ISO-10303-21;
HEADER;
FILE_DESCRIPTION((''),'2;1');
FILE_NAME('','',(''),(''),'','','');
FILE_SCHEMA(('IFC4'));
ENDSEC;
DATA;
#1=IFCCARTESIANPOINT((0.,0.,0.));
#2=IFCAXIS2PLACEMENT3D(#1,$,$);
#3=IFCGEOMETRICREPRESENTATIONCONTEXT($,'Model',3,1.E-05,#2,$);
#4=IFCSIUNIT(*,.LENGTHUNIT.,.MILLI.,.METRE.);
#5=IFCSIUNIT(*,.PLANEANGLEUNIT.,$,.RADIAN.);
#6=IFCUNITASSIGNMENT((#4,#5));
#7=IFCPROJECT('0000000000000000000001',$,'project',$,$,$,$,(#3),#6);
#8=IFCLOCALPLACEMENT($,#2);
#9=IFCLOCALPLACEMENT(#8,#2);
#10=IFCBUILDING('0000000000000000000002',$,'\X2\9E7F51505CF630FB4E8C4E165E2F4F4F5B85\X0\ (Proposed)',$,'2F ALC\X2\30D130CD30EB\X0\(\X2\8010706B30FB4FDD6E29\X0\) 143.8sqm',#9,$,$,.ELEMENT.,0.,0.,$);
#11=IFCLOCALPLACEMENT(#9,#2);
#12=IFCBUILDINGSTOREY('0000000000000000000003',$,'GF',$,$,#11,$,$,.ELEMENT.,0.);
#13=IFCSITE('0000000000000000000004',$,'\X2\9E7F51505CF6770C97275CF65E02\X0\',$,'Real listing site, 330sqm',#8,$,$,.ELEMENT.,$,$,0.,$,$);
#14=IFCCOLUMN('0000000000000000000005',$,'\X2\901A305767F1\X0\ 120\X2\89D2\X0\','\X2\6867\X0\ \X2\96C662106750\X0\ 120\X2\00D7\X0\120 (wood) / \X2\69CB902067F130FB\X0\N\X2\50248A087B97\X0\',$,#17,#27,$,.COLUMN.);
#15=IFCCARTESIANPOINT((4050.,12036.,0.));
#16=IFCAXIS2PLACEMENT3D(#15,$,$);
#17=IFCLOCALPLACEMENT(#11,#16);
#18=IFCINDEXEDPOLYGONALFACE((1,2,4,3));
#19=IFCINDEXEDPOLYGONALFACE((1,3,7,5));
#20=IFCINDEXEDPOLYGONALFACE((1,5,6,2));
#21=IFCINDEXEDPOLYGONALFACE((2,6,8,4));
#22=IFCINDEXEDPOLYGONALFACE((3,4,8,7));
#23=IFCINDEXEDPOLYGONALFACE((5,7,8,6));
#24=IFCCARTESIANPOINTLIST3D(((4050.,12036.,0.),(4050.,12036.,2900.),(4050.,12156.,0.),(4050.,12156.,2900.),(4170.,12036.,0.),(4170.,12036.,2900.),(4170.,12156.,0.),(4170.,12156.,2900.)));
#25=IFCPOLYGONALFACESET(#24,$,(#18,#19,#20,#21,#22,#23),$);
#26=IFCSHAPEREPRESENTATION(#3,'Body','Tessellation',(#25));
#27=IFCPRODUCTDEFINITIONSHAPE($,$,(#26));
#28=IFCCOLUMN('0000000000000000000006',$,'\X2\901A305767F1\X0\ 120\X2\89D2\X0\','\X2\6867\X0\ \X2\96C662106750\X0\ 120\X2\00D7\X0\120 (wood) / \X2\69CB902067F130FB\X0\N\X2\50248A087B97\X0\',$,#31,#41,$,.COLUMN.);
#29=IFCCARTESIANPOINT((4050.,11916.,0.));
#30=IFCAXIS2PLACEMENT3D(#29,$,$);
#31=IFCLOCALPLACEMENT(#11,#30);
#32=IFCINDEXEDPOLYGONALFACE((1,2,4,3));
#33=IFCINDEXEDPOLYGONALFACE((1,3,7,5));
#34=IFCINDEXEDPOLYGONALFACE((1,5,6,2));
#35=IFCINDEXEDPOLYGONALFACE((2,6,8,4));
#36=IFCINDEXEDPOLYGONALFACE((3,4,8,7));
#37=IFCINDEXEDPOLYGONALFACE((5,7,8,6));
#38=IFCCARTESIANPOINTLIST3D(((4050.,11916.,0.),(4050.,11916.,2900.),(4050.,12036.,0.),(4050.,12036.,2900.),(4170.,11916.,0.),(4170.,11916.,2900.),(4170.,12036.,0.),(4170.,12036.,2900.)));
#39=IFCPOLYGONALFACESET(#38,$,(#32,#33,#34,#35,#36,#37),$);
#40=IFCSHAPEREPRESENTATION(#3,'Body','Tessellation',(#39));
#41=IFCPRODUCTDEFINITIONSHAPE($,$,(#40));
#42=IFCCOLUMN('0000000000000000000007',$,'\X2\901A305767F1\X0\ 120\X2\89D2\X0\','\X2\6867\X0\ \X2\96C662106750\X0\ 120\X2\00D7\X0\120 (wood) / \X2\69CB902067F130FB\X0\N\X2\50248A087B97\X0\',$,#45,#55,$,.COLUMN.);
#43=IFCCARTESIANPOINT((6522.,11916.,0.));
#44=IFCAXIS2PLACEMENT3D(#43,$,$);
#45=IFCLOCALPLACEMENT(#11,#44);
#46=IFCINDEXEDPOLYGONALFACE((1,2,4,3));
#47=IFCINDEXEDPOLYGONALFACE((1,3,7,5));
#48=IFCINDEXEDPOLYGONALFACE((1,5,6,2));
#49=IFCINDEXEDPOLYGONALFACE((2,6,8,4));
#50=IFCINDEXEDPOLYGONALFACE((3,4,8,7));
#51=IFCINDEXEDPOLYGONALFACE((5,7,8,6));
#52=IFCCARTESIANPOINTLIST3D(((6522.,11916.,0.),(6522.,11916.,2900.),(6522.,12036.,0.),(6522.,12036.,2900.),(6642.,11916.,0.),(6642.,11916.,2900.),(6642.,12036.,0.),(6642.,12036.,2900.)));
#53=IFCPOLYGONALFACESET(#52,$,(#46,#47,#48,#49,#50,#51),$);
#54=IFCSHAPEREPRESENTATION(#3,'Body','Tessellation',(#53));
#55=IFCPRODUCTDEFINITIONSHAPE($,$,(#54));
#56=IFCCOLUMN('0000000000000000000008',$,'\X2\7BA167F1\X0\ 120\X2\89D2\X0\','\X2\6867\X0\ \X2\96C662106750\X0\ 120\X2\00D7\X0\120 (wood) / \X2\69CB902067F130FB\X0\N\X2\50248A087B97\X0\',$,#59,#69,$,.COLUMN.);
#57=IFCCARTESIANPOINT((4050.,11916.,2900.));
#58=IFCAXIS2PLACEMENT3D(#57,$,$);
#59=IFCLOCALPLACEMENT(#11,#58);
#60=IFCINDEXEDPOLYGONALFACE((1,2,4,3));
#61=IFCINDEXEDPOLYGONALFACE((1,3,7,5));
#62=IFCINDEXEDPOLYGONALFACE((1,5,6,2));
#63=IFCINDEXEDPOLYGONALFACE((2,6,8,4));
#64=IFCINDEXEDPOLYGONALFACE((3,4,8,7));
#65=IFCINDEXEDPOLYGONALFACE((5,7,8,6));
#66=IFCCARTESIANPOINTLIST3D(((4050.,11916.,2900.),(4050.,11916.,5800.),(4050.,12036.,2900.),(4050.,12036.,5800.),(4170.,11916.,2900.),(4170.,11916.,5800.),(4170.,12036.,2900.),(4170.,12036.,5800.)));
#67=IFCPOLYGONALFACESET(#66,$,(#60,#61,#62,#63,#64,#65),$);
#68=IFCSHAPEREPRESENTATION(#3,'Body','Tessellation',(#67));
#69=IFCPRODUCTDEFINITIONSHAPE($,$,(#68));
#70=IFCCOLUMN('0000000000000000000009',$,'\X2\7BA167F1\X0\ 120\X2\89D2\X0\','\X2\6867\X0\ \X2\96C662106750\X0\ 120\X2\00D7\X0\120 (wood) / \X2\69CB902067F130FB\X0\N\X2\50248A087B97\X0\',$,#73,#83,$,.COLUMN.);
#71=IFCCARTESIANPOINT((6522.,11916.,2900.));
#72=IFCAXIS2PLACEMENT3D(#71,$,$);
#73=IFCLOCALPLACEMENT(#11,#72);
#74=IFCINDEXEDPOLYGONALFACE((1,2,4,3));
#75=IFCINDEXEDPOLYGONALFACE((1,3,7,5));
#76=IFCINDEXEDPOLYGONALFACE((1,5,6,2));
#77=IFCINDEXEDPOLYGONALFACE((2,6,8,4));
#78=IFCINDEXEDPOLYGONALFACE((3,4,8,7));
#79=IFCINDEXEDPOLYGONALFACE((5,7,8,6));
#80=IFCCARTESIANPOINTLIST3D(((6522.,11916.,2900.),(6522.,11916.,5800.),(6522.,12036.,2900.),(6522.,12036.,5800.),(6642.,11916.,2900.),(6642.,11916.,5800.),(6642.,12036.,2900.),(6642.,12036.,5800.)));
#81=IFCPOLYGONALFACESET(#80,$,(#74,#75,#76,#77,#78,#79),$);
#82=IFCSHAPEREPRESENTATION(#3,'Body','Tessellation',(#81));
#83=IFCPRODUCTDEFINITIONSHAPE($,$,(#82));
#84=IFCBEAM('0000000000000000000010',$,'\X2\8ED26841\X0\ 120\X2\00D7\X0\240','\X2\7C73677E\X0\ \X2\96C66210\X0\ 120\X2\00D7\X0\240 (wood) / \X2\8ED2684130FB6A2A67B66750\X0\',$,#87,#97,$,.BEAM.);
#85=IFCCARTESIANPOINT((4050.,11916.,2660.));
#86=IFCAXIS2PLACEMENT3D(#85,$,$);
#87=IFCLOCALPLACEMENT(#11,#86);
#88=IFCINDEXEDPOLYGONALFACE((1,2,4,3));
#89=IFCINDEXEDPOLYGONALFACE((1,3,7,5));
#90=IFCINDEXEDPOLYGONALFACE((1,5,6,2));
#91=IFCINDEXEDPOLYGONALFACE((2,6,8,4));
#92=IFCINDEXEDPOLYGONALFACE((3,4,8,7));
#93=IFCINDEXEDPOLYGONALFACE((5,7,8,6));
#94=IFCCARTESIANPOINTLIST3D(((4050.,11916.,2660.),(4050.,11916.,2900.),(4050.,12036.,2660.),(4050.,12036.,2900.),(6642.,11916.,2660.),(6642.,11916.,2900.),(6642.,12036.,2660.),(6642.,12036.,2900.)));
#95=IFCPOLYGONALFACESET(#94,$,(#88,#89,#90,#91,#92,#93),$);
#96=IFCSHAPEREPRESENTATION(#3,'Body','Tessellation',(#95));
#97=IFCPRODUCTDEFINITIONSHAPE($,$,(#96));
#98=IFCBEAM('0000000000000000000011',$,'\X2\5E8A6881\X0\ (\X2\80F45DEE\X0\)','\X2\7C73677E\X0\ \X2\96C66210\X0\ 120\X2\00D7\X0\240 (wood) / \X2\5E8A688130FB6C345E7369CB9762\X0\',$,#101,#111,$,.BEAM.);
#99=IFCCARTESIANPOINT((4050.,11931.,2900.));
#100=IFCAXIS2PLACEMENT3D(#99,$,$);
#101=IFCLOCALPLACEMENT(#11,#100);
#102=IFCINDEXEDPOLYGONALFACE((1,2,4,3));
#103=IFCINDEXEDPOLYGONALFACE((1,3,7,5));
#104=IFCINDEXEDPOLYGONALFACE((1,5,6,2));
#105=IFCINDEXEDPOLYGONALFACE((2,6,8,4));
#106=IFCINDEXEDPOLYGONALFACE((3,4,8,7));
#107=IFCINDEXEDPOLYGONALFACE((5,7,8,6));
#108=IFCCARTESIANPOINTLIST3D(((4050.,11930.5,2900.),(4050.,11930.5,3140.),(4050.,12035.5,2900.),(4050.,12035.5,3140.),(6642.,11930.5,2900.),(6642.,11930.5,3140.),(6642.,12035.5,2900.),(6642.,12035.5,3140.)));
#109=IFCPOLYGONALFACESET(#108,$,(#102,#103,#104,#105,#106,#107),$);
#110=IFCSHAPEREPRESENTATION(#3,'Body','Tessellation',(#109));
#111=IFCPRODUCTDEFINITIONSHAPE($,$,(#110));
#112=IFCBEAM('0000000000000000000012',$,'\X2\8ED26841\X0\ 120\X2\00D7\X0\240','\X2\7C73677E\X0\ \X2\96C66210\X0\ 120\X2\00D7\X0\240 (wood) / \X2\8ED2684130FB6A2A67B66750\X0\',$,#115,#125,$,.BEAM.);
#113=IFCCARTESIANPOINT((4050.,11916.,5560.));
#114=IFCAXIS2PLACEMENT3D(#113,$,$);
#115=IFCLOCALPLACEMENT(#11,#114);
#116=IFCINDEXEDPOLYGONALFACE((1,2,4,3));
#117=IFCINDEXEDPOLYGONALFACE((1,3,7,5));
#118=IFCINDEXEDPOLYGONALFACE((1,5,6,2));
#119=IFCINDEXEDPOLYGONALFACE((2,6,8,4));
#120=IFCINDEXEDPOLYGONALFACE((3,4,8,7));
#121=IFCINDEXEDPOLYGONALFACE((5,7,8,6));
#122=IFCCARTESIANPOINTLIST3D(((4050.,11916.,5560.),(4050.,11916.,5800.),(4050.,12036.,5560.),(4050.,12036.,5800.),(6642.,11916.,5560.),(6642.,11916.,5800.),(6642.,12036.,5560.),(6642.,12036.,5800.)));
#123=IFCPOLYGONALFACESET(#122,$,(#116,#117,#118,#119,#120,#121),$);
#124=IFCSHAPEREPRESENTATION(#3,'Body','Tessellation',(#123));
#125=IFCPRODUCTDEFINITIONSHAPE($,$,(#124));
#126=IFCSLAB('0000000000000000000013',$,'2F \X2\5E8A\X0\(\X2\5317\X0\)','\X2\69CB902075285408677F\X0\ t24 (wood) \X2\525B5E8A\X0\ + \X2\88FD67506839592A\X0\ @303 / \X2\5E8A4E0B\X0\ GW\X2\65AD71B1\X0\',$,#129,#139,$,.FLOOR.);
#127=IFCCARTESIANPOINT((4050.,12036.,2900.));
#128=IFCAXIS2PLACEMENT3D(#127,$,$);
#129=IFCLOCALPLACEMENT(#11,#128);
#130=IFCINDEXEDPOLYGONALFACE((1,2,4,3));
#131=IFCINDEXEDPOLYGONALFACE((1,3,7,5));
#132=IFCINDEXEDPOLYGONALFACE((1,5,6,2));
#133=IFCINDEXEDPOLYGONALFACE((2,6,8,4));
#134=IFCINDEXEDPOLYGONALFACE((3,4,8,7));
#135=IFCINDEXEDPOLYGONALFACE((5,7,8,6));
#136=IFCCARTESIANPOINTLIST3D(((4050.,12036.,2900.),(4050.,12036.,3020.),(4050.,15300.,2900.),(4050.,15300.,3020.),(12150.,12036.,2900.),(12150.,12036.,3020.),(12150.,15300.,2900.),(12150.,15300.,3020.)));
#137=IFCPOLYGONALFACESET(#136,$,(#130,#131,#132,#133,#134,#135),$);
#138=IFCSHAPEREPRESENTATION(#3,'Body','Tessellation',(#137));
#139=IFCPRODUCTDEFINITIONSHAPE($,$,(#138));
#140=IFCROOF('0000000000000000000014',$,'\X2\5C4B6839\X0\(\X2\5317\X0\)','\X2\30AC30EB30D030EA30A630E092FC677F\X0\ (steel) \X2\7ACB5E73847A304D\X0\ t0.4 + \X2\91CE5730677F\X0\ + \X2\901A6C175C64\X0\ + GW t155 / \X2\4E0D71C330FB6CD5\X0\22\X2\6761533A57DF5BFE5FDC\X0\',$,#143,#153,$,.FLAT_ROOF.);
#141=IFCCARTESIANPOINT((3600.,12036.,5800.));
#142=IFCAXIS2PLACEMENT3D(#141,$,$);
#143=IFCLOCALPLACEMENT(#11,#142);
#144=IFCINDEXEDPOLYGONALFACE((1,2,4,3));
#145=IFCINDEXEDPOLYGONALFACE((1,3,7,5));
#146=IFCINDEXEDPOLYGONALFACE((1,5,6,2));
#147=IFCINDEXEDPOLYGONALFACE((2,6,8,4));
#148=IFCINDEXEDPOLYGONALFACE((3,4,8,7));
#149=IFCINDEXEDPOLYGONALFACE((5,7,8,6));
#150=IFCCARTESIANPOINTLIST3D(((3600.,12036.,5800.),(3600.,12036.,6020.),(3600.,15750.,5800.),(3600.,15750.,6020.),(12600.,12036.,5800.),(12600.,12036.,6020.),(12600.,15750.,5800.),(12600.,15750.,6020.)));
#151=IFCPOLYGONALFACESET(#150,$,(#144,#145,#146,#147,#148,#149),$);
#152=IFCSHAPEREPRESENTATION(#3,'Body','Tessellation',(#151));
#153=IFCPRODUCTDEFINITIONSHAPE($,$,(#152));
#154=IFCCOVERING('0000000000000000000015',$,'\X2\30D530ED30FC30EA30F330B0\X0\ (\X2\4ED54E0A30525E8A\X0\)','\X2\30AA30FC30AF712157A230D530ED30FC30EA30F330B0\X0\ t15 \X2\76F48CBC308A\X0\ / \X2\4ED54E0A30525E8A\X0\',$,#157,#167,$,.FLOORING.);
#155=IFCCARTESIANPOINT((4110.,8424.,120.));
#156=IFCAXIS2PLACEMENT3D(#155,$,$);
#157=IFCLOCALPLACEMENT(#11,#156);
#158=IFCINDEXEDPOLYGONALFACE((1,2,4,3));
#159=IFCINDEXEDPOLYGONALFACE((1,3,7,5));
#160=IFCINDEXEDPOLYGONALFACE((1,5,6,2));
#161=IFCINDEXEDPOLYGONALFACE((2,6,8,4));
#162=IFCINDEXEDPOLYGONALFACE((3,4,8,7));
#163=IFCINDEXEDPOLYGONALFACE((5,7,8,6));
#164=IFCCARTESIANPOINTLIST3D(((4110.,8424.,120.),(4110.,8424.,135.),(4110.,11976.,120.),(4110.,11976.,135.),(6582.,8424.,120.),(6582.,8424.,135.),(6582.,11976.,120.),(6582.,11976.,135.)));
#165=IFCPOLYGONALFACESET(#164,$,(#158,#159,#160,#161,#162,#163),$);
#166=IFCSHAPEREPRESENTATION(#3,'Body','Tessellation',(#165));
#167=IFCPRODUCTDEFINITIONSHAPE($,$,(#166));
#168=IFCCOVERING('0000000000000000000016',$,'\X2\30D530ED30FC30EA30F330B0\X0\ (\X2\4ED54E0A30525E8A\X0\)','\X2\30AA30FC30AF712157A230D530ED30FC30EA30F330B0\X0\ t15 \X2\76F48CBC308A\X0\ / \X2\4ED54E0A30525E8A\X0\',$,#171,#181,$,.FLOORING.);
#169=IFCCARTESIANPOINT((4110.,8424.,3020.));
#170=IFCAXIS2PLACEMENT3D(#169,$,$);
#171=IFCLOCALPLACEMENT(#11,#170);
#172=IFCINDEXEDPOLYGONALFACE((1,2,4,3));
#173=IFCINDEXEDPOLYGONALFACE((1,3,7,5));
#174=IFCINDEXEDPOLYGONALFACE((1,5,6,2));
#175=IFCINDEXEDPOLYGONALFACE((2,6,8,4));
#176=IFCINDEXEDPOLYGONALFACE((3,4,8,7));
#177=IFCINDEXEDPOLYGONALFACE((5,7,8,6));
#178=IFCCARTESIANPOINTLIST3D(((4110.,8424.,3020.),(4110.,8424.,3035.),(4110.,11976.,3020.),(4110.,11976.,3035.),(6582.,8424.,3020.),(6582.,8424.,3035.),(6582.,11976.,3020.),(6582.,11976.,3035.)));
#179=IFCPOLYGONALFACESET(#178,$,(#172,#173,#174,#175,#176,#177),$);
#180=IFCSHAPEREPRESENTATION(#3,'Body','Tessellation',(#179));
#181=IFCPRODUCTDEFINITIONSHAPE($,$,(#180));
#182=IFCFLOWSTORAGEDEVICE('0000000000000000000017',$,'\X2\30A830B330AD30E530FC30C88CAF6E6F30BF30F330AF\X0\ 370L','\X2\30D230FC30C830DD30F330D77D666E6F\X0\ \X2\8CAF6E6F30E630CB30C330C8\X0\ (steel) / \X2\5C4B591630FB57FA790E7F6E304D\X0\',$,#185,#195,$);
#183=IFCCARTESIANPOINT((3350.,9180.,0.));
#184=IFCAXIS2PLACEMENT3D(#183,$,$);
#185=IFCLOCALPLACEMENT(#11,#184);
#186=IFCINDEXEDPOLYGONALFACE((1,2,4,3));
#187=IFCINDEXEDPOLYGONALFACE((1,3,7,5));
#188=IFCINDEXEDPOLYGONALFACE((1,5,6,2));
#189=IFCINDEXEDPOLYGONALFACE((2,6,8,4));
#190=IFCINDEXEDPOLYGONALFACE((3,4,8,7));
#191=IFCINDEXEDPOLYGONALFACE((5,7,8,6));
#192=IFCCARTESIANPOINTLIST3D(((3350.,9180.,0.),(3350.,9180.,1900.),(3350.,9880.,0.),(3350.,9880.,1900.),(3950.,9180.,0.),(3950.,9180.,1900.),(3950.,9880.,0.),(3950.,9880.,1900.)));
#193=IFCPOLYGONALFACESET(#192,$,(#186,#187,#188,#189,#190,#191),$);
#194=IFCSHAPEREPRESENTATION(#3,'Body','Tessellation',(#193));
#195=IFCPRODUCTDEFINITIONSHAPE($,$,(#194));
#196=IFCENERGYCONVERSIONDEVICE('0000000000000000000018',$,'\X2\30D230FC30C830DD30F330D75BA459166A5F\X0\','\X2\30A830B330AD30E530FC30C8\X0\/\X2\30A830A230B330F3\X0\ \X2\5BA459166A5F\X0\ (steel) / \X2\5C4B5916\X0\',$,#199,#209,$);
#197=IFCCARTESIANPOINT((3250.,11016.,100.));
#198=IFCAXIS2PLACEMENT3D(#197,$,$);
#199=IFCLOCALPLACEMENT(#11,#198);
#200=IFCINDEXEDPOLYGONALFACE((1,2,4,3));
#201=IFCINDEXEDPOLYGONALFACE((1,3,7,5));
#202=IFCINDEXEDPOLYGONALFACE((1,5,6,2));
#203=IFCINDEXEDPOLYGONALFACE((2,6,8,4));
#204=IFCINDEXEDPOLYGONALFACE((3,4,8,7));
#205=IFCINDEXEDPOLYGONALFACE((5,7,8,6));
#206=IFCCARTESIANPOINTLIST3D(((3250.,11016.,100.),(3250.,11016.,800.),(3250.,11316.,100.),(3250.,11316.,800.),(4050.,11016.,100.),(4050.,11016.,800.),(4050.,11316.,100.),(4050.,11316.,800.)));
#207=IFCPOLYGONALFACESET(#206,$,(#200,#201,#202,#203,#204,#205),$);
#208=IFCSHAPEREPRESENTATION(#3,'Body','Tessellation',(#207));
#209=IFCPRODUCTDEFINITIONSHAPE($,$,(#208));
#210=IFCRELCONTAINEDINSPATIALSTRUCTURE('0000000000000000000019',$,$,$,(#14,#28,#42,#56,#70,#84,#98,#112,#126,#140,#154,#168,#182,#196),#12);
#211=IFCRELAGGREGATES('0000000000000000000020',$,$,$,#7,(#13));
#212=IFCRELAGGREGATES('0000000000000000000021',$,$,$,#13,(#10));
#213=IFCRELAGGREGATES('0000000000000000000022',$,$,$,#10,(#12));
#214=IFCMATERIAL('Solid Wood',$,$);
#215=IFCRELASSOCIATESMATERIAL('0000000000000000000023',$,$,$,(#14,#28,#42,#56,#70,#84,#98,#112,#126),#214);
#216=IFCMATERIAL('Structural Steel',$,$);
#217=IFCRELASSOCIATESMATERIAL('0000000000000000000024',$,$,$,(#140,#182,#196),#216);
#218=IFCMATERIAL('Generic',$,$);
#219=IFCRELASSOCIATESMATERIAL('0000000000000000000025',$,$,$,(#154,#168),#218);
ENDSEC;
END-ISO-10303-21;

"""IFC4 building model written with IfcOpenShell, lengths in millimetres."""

from ifc_helpers import new_model, si_unit, frame, frame_2d, origin, place, context, project, spatial, rectangle, extrude, material, element, save


model = new_model("IFC4")

# Units and contexts
model_context = context("Model", 3, precision=1e-05, world=origin())
ifc_project = project(units=[si_unit("LENGTHUNIT", "METRE", prefix="MILLI"), si_unit("PLANEANGLEUNIT", "RADIAN")], contexts=[model_context])

# Site, building, storey
site_placement = place(None, origin())
site = spatial("IfcSite", under=ifc_project, at=site_placement, Name="鹿児島県霧島市", ObjectType="Real listing site, 330sqm", CompositionType="ELEMENT", RefElevation=0.0)
building_placement = place(site_placement, origin())
building = spatial("IfcBuilding", under=site, at=building_placement, Name="鹿児島・二世帯住宅 (Proposed)", ObjectType="2F ALCパネル(耐火・保温) 143.8sqm", CompositionType="ELEMENT", ElevationOfRefHeight=0.0, ElevationOfTerrain=0.0)
storey_placement = place(building_placement, origin())
storey = spatial("IfcBuildingStorey", under=building, at=storey_placement, Name="GF", CompositionType="ELEMENT", Elevation=0.0)

# Columns
ifc_material_1 = material(Name="Solid Wood")
column_1_placement = place(storey_placement, frame((4050.0, 12036.0, 0.0)))
element("IfcColumn", 1, at=column_1_placement, inside=storey, material=ifc_material_1, Name="通し柱 120角", Description="桧 集成材 120×120 (wood) / 構造柱・N値計算", PredefinedType="COLUMN", context=model_context, shape_type="SweptSolid", body=[
    extrude(rectangle(XDim=120.0, YDim=120.0, at=frame_2d((60.0, 60.0))), frame((4050.0, 12036.0, 0.0)), (0.0, 0.0, 1.0), 2900.0),
])
column_2_placement = place(storey_placement, frame((4050.0, 11916.0, 0.0)))
element("IfcColumn", 2, at=column_2_placement, inside=storey, material=ifc_material_1, Name="通し柱 120角", Description="桧 集成材 120×120 (wood) / 構造柱・N値計算", PredefinedType="COLUMN", context=model_context, shape_type="SweptSolid", body=[
    extrude(rectangle(XDim=120.0, YDim=120.0, at=frame_2d((60.0, 60.0))), frame((4050.0, 11916.0, 0.0)), (0.0, 0.0, 1.0), 2900.0),
])
column_3_placement = place(storey_placement, frame((6522.0, 11916.0, 0.0)))
element("IfcColumn", 3, at=column_3_placement, inside=storey, material=ifc_material_1, Name="通し柱 120角", Description="桧 集成材 120×120 (wood) / 構造柱・N値計算", PredefinedType="COLUMN", context=model_context, shape_type="SweptSolid", body=[
    extrude(rectangle(XDim=120.0, YDim=120.0, at=frame_2d((60.0, 60.0))), frame((6522.0, 11916.0, 0.0)), (0.0, 0.0, 1.0), 2900.0),
])
column_4_placement = place(storey_placement, frame((4050.0, 11916.0, 2900.0)))
element("IfcColumn", 4, at=column_4_placement, inside=storey, material=ifc_material_1, Name="管柱 120角", Description="桧 集成材 120×120 (wood) / 構造柱・N値計算", PredefinedType="COLUMN", context=model_context, shape_type="SweptSolid", body=[
    extrude(rectangle(XDim=120.0, YDim=120.0, at=frame_2d((60.0, 60.0))), frame((4050.0, 11916.0, 2900.0)), (0.0, 0.0, 1.0), 2900.0),
])
column_5_placement = place(storey_placement, frame((6522.0, 11916.0, 2900.0)))
element("IfcColumn", 5, at=column_5_placement, inside=storey, material=ifc_material_1, Name="管柱 120角", Description="桧 集成材 120×120 (wood) / 構造柱・N値計算", PredefinedType="COLUMN", context=model_context, shape_type="SweptSolid", body=[
    extrude(rectangle(XDim=120.0, YDim=120.0, at=frame_2d((60.0, 60.0))), frame((6522.0, 11916.0, 2900.0)), (0.0, 0.0, 1.0), 2900.0),
])

# Beams
beam_1_placement = place(storey_placement, frame((4050.0, 11916.0, 2660.0)))
element("IfcBeam", 6, at=beam_1_placement, inside=storey, material=ifc_material_1, Name="軒桁 120×240", Description="米松 集成 120×240 (wood) / 軒桁・横架材", PredefinedType="BEAM", context=model_context, shape_type="SweptSolid", body=[
    extrude(rectangle(XDim=2592.0, YDim=120.0, at=frame_2d((1296.0, 60.0))), frame((4050.0, 11916.0, 2660.0)), (0.0, 0.0, 1.0), 240.0),
])
beam_2_placement = place(storey_placement, frame((4050.0, 11931.0, 2900.0)))
element("IfcBeam", 7, at=beam_2_placement, inside=storey, material=ifc_material_1, Name="床梁 (胴差)", Description="米松 集成 120×240 (wood) / 床梁・水平構面", PredefinedType="BEAM", context=model_context, shape_type="SweptSolid", body=[
    extrude(rectangle(XDim=2592.0, YDim=105.0, at=frame_2d((1296.0, 52.0))), frame((4050.0, 11931.0, 2900.0)), (0.0, 0.0, 1.0), 240.0),
])
beam_3_placement = place(storey_placement, frame((4050.0, 11916.0, 5560.0)))
element("IfcBeam", 8, at=beam_3_placement, inside=storey, material=ifc_material_1, Name="軒桁 120×240", Description="米松 集成 120×240 (wood) / 軒桁・横架材", PredefinedType="BEAM", context=model_context, shape_type="SweptSolid", body=[
    extrude(rectangle(XDim=2592.0, YDim=120.0, at=frame_2d((1296.0, 60.0))), frame((4050.0, 11916.0, 5560.0)), (0.0, 0.0, 1.0), 240.0),
])

# Slab
slab_1_placement = place(storey_placement, frame((4050.0, 12036.0, 2900.0)))
element("IfcSlab", 9, at=slab_1_placement, inside=storey, material=ifc_material_1, Name="2F 床(北)", Description="構造用合板 t24 (wood) 剛床 + 製材根太 @303 / 床下 GW断熱", PredefinedType="FLOOR", context=model_context, shape_type="SweptSolid", body=[
    extrude(rectangle(XDim=8100.0, YDim=3264.0, at=frame_2d((4050.0, 1632.0))), frame((4050.0, 12036.0, 2900.0)), (0.0, 0.0, 1.0), 120.0),
])

# Roof
ifc_material_2 = material(Name="Structural Steel")
for number, where, name in (
    (10, (3600.0, 12036.0, 5800.0), "屋根(北)"),
):
    element("IfcRoof", number, at=place(storey_placement, frame(where)), inside=storey, material=ifc_material_2, Name=name, Description="ガルバリウム鋼板 (steel) 立平葺き t0.4 + 野地板 + 通気層 + GW t155 / 不燃・法22条区域対応", PredefinedType="FLAT_ROOF", context=model_context, shape_type="SweptSolid", body=[
        extrude(rectangle(XDim=9000.0, YDim=3714.0, at=frame_2d((4500.0, 1857.0))), frame((3600.0, 12036.0, 5800.0)), (0.0, 0.0, 1.0), 220.0),
    ])

# Coverings
ifc_material_3 = material(Name="Generic")
covering_1_placement = place(storey_placement, frame((4110.0, 8424.0, 120.0)))
element("IfcCovering", 11, at=covering_1_placement, inside=storey, material=ifc_material_3, Name="フローリング (仕上げ床)", Description="オーク無垢フローリング t15 直貼り / 仕上げ床", PredefinedType="FLOORING", context=model_context, shape_type="SweptSolid", body=[
    extrude(rectangle(XDim=2472.0, YDim=3552.0, at=frame_2d((1236.0, 1776.0))), frame((4110.0, 8424.0, 120.0)), (0.0, 0.0, 1.0), 15.0),
])
covering_2_placement = place(storey_placement, frame((4110.0, 8424.0, 3020.0)))
element("IfcCovering", 12, at=covering_2_placement, inside=storey, material=ifc_material_3, Name="フローリング (仕上げ床)", Description="オーク無垢フローリング t15 直貼り / 仕上げ床", PredefinedType="FLOORING", context=model_context, shape_type="SweptSolid", body=[
    extrude(rectangle(XDim=2472.0, YDim=3552.0, at=frame_2d((1236.0, 1776.0))), frame((4110.0, 8424.0, 3020.0)), (0.0, 0.0, 1.0), 15.0),
])

# Flow storage device
flow_storage_device_placement = place(storey_placement, frame((3350.0, 9180.0, 0.0)))
element("IfcFlowStorageDevice", 13, at=flow_storage_device_placement, inside=storey, material=ifc_material_2, Name="エコキュート貯湯タンク 370L", Description="ヒートポンプ給湯 貯湯ユニット (steel) / 屋外・基礎置き", context=model_context, shape_type="SweptSolid", body=[
    extrude(rectangle(XDim=600.0, YDim=700.0, at=frame_2d((300.0, 350.0))), frame((3350.0, 9180.0, 0.0)), (0.0, 0.0, 1.0), 1900.0),
])

# Energy conversion device
energy_conversion_device_placement = place(storey_placement, frame((3250.0, 11016.0, 100.0)))
element("IfcEnergyConversionDevice", 14, at=energy_conversion_device_placement, inside=storey, material=ifc_material_2, Name="ヒートポンプ室外機", Description="エコキュート/エアコン 室外機 (steel) / 屋外", context=model_context, shape_type="SweptSolid", body=[
    extrude(rectangle(XDim=800.0, YDim=300.0, at=frame_2d((400.0, 150.0))), frame((3250.0, 11016.0, 100.0)), (0.0, 0.0, 1.0), 700.0),
])

save(model, "model.ifc")
